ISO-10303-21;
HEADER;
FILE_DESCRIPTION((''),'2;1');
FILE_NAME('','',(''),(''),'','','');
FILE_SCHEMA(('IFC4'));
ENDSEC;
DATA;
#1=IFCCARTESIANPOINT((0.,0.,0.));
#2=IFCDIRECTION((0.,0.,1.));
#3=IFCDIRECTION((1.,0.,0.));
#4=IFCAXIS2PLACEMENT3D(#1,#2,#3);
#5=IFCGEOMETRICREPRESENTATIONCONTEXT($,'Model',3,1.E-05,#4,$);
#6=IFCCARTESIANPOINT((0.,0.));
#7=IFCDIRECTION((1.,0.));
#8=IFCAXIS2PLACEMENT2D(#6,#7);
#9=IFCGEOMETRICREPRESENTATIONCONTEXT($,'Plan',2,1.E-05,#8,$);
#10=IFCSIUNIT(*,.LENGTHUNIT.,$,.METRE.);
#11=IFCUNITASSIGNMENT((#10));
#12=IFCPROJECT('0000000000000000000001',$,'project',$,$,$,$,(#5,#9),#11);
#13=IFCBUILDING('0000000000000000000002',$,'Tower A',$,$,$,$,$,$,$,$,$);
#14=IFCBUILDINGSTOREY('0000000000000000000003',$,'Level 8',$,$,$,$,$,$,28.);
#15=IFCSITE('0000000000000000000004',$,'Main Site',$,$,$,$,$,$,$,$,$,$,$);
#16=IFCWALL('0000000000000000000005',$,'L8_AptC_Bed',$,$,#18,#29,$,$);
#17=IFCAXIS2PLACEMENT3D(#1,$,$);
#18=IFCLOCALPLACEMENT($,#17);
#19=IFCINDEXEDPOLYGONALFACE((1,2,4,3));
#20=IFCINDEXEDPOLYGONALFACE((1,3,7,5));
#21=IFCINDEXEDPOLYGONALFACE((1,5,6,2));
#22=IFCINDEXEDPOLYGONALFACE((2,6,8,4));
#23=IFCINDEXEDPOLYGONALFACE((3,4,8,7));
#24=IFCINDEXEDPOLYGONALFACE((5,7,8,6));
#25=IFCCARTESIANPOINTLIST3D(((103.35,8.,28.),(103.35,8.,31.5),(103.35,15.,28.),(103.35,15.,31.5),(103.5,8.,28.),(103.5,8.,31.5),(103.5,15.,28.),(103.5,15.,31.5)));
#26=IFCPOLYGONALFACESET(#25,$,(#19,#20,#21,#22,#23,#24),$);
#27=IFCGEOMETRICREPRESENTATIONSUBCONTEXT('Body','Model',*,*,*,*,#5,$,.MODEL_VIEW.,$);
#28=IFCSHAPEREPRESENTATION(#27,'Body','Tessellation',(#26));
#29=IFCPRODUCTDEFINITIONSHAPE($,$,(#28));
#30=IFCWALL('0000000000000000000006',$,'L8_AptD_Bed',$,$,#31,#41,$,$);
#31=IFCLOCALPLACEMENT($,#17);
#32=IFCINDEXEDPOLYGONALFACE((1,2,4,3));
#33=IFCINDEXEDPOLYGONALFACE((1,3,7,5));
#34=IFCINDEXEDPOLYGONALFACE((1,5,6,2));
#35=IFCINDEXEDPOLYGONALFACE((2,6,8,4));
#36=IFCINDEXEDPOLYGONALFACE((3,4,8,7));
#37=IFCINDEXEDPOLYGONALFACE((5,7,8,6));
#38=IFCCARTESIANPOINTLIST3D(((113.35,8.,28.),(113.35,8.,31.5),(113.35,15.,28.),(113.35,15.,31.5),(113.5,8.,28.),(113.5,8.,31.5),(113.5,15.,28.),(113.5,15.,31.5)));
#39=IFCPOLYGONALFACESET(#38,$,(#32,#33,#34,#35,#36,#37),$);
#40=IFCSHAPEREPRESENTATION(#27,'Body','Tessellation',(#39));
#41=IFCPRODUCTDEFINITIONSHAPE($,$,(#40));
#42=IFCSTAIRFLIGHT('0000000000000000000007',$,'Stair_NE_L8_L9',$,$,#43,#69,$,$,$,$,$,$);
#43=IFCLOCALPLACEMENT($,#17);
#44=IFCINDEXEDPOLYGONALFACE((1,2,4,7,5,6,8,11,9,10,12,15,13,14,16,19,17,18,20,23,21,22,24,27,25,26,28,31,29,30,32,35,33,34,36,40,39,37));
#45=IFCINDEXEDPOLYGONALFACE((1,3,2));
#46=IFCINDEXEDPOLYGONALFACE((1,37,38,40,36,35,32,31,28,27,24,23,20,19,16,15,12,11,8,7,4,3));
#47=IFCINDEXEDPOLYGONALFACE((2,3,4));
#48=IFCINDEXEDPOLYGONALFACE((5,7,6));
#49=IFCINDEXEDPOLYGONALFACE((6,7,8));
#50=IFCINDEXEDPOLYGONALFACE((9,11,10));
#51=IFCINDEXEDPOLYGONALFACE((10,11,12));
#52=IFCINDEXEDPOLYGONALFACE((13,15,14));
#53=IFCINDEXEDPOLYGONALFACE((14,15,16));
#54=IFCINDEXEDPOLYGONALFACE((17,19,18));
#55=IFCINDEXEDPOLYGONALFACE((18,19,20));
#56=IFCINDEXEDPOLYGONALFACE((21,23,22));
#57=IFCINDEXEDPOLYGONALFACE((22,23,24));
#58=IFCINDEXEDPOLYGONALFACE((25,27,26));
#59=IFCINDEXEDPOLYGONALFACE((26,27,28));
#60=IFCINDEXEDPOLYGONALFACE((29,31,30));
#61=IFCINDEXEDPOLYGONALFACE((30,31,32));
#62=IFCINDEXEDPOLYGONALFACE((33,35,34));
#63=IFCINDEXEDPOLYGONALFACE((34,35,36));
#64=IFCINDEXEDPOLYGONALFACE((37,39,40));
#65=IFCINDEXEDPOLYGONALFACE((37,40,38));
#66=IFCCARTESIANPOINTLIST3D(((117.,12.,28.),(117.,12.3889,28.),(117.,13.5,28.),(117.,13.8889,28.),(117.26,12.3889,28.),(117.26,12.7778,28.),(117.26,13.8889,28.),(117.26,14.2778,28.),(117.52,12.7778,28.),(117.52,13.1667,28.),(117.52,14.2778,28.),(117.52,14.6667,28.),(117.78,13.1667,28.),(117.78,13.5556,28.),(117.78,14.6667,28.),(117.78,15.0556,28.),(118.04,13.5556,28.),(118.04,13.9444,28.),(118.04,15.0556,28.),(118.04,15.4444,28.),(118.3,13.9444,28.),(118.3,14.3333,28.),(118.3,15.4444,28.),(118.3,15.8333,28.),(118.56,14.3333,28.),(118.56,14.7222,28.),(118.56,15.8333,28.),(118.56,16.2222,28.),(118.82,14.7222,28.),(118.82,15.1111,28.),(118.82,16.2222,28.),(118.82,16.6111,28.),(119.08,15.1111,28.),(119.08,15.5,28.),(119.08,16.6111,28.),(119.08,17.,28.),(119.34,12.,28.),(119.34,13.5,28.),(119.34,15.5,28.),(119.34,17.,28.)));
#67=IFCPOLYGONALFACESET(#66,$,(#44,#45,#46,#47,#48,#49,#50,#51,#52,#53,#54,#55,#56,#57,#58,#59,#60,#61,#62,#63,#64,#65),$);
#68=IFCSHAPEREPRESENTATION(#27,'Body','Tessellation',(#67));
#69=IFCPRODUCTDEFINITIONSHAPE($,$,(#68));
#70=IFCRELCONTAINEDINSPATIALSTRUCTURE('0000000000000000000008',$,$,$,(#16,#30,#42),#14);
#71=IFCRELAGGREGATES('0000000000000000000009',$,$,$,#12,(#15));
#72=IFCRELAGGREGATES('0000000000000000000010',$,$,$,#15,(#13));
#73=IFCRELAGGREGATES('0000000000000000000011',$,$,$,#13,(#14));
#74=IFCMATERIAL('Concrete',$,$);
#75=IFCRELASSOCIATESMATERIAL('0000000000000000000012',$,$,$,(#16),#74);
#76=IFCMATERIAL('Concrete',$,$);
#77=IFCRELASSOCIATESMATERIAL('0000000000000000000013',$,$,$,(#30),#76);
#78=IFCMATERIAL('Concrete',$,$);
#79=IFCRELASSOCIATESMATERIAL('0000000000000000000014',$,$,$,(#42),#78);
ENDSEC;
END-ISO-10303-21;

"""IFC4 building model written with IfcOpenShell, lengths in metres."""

from ifc_helpers import new_model, si_unit, frame, origin_with_axes, origin_2d_with_axis, place, context, subcontext, project, spatial, line, indexed_curve, outline, extrude, material, element, save


model = new_model("IFC4")

# Units and contexts
model_context = context("Model", 3, precision=1e-05, world=origin_with_axes())
plan_context = context("Plan", 2, precision=1e-05, world=origin_2d_with_axis())
body_context = subcontext(model_context, "Body", "Model", "MODEL_VIEW")
ifc_project = project(units=[si_unit("LENGTHUNIT", "METRE")], contexts=[model_context, plan_context])

# Site, building, storey
site = spatial("IfcSite", under=ifc_project, Name="Main Site")
building = spatial("IfcBuilding", under=site, Name="Tower A")
storey = spatial("IfcBuildingStorey", under=building, Name="Level 8", Elevation=28.0)

# Walls
ifc_material_1 = material(Name="Concrete")
wall_1_placement = place(None, frame((103.5, 8.0, 28.0), z_axis=(0.0, 0.0, 1.0), x_axis=(0.0, 1.0, 0.0)))
element("IfcWall", 1, at=wall_1_placement, inside=storey, material=ifc_material_1, Name="L8_AptC_Bed", context=body_context, shape_type="SweptSolid", body=[
    extrude(outline(indexed_curve([(0.0, 0.0), (0.0, 0.15), (7.0, 0.15), (7.0, 0.0), (0.0, 0.0)], self_intersect=False)), origin_with_axes(), (0.0, 0.0, 1.0), 3.5),
])
ifc_material_2 = material(Name="Concrete")
wall_2_placement = place(None, frame((113.5, 8.0, 28.0), z_axis=(0.0, 0.0, 1.0), x_axis=(0.0, 1.0, 0.0)))
element("IfcWall", 2, at=wall_2_placement, inside=storey, material=ifc_material_2, Name="L8_AptD_Bed", context=body_context, shape_type="SweptSolid", body=[
    extrude(outline(indexed_curve([(0.0, 0.0), (0.0, 0.15), (7.0, 0.15), (7.0, 0.0), (0.0, 0.0)], self_intersect=False)), origin_with_axes(), (0.0, 0.0, 1.0), 3.5),
])

# Stair flight
ifc_material_3 = material(Name="Concrete")
stair_flight_placement = place(None, frame((117.0, 12.0, 28.0), z_axis=(0.0, 0.0, 1.0), x_axis=(1.0, 0.0, 0.0)))
element("IfcStairFlight", 3, at=stair_flight_placement, inside=storey, material=ifc_material_3, Name="Stair_NE_L8_L9", context=body_context, shape_type="SweptSolid", body=[
    extrude(outline(indexed_curve([(0.0, 0.0), (0.0, 0.3889), (0.26, 0.3889), (0.26, 0.7778), (0.52, 0.7778), (0.52, 1.1667), (0.78, 1.1667), (0.78, 1.5556), (1.04, 1.5556), (1.04, 1.9444), (1.3, 1.9444), (1.3, 2.3333), (1.56, 2.3333), (1.56, 2.7222), (1.82, 2.7222), (1.82, 3.1111), (2.08, 3.1111), (2.08, 3.5), (2.34, 3.5), (2.34, 0.0)], segments=[line(1, 2, 3, 4, 5, 6, 7, 8, 9, 10, 11, 12, 13, 14, 15, 16, 17, 18, 19, 20, 1)])), origin_with_axes(), (0.0, 1.0, 0.0), 1.5),
])

save(model, "model.ifc")
